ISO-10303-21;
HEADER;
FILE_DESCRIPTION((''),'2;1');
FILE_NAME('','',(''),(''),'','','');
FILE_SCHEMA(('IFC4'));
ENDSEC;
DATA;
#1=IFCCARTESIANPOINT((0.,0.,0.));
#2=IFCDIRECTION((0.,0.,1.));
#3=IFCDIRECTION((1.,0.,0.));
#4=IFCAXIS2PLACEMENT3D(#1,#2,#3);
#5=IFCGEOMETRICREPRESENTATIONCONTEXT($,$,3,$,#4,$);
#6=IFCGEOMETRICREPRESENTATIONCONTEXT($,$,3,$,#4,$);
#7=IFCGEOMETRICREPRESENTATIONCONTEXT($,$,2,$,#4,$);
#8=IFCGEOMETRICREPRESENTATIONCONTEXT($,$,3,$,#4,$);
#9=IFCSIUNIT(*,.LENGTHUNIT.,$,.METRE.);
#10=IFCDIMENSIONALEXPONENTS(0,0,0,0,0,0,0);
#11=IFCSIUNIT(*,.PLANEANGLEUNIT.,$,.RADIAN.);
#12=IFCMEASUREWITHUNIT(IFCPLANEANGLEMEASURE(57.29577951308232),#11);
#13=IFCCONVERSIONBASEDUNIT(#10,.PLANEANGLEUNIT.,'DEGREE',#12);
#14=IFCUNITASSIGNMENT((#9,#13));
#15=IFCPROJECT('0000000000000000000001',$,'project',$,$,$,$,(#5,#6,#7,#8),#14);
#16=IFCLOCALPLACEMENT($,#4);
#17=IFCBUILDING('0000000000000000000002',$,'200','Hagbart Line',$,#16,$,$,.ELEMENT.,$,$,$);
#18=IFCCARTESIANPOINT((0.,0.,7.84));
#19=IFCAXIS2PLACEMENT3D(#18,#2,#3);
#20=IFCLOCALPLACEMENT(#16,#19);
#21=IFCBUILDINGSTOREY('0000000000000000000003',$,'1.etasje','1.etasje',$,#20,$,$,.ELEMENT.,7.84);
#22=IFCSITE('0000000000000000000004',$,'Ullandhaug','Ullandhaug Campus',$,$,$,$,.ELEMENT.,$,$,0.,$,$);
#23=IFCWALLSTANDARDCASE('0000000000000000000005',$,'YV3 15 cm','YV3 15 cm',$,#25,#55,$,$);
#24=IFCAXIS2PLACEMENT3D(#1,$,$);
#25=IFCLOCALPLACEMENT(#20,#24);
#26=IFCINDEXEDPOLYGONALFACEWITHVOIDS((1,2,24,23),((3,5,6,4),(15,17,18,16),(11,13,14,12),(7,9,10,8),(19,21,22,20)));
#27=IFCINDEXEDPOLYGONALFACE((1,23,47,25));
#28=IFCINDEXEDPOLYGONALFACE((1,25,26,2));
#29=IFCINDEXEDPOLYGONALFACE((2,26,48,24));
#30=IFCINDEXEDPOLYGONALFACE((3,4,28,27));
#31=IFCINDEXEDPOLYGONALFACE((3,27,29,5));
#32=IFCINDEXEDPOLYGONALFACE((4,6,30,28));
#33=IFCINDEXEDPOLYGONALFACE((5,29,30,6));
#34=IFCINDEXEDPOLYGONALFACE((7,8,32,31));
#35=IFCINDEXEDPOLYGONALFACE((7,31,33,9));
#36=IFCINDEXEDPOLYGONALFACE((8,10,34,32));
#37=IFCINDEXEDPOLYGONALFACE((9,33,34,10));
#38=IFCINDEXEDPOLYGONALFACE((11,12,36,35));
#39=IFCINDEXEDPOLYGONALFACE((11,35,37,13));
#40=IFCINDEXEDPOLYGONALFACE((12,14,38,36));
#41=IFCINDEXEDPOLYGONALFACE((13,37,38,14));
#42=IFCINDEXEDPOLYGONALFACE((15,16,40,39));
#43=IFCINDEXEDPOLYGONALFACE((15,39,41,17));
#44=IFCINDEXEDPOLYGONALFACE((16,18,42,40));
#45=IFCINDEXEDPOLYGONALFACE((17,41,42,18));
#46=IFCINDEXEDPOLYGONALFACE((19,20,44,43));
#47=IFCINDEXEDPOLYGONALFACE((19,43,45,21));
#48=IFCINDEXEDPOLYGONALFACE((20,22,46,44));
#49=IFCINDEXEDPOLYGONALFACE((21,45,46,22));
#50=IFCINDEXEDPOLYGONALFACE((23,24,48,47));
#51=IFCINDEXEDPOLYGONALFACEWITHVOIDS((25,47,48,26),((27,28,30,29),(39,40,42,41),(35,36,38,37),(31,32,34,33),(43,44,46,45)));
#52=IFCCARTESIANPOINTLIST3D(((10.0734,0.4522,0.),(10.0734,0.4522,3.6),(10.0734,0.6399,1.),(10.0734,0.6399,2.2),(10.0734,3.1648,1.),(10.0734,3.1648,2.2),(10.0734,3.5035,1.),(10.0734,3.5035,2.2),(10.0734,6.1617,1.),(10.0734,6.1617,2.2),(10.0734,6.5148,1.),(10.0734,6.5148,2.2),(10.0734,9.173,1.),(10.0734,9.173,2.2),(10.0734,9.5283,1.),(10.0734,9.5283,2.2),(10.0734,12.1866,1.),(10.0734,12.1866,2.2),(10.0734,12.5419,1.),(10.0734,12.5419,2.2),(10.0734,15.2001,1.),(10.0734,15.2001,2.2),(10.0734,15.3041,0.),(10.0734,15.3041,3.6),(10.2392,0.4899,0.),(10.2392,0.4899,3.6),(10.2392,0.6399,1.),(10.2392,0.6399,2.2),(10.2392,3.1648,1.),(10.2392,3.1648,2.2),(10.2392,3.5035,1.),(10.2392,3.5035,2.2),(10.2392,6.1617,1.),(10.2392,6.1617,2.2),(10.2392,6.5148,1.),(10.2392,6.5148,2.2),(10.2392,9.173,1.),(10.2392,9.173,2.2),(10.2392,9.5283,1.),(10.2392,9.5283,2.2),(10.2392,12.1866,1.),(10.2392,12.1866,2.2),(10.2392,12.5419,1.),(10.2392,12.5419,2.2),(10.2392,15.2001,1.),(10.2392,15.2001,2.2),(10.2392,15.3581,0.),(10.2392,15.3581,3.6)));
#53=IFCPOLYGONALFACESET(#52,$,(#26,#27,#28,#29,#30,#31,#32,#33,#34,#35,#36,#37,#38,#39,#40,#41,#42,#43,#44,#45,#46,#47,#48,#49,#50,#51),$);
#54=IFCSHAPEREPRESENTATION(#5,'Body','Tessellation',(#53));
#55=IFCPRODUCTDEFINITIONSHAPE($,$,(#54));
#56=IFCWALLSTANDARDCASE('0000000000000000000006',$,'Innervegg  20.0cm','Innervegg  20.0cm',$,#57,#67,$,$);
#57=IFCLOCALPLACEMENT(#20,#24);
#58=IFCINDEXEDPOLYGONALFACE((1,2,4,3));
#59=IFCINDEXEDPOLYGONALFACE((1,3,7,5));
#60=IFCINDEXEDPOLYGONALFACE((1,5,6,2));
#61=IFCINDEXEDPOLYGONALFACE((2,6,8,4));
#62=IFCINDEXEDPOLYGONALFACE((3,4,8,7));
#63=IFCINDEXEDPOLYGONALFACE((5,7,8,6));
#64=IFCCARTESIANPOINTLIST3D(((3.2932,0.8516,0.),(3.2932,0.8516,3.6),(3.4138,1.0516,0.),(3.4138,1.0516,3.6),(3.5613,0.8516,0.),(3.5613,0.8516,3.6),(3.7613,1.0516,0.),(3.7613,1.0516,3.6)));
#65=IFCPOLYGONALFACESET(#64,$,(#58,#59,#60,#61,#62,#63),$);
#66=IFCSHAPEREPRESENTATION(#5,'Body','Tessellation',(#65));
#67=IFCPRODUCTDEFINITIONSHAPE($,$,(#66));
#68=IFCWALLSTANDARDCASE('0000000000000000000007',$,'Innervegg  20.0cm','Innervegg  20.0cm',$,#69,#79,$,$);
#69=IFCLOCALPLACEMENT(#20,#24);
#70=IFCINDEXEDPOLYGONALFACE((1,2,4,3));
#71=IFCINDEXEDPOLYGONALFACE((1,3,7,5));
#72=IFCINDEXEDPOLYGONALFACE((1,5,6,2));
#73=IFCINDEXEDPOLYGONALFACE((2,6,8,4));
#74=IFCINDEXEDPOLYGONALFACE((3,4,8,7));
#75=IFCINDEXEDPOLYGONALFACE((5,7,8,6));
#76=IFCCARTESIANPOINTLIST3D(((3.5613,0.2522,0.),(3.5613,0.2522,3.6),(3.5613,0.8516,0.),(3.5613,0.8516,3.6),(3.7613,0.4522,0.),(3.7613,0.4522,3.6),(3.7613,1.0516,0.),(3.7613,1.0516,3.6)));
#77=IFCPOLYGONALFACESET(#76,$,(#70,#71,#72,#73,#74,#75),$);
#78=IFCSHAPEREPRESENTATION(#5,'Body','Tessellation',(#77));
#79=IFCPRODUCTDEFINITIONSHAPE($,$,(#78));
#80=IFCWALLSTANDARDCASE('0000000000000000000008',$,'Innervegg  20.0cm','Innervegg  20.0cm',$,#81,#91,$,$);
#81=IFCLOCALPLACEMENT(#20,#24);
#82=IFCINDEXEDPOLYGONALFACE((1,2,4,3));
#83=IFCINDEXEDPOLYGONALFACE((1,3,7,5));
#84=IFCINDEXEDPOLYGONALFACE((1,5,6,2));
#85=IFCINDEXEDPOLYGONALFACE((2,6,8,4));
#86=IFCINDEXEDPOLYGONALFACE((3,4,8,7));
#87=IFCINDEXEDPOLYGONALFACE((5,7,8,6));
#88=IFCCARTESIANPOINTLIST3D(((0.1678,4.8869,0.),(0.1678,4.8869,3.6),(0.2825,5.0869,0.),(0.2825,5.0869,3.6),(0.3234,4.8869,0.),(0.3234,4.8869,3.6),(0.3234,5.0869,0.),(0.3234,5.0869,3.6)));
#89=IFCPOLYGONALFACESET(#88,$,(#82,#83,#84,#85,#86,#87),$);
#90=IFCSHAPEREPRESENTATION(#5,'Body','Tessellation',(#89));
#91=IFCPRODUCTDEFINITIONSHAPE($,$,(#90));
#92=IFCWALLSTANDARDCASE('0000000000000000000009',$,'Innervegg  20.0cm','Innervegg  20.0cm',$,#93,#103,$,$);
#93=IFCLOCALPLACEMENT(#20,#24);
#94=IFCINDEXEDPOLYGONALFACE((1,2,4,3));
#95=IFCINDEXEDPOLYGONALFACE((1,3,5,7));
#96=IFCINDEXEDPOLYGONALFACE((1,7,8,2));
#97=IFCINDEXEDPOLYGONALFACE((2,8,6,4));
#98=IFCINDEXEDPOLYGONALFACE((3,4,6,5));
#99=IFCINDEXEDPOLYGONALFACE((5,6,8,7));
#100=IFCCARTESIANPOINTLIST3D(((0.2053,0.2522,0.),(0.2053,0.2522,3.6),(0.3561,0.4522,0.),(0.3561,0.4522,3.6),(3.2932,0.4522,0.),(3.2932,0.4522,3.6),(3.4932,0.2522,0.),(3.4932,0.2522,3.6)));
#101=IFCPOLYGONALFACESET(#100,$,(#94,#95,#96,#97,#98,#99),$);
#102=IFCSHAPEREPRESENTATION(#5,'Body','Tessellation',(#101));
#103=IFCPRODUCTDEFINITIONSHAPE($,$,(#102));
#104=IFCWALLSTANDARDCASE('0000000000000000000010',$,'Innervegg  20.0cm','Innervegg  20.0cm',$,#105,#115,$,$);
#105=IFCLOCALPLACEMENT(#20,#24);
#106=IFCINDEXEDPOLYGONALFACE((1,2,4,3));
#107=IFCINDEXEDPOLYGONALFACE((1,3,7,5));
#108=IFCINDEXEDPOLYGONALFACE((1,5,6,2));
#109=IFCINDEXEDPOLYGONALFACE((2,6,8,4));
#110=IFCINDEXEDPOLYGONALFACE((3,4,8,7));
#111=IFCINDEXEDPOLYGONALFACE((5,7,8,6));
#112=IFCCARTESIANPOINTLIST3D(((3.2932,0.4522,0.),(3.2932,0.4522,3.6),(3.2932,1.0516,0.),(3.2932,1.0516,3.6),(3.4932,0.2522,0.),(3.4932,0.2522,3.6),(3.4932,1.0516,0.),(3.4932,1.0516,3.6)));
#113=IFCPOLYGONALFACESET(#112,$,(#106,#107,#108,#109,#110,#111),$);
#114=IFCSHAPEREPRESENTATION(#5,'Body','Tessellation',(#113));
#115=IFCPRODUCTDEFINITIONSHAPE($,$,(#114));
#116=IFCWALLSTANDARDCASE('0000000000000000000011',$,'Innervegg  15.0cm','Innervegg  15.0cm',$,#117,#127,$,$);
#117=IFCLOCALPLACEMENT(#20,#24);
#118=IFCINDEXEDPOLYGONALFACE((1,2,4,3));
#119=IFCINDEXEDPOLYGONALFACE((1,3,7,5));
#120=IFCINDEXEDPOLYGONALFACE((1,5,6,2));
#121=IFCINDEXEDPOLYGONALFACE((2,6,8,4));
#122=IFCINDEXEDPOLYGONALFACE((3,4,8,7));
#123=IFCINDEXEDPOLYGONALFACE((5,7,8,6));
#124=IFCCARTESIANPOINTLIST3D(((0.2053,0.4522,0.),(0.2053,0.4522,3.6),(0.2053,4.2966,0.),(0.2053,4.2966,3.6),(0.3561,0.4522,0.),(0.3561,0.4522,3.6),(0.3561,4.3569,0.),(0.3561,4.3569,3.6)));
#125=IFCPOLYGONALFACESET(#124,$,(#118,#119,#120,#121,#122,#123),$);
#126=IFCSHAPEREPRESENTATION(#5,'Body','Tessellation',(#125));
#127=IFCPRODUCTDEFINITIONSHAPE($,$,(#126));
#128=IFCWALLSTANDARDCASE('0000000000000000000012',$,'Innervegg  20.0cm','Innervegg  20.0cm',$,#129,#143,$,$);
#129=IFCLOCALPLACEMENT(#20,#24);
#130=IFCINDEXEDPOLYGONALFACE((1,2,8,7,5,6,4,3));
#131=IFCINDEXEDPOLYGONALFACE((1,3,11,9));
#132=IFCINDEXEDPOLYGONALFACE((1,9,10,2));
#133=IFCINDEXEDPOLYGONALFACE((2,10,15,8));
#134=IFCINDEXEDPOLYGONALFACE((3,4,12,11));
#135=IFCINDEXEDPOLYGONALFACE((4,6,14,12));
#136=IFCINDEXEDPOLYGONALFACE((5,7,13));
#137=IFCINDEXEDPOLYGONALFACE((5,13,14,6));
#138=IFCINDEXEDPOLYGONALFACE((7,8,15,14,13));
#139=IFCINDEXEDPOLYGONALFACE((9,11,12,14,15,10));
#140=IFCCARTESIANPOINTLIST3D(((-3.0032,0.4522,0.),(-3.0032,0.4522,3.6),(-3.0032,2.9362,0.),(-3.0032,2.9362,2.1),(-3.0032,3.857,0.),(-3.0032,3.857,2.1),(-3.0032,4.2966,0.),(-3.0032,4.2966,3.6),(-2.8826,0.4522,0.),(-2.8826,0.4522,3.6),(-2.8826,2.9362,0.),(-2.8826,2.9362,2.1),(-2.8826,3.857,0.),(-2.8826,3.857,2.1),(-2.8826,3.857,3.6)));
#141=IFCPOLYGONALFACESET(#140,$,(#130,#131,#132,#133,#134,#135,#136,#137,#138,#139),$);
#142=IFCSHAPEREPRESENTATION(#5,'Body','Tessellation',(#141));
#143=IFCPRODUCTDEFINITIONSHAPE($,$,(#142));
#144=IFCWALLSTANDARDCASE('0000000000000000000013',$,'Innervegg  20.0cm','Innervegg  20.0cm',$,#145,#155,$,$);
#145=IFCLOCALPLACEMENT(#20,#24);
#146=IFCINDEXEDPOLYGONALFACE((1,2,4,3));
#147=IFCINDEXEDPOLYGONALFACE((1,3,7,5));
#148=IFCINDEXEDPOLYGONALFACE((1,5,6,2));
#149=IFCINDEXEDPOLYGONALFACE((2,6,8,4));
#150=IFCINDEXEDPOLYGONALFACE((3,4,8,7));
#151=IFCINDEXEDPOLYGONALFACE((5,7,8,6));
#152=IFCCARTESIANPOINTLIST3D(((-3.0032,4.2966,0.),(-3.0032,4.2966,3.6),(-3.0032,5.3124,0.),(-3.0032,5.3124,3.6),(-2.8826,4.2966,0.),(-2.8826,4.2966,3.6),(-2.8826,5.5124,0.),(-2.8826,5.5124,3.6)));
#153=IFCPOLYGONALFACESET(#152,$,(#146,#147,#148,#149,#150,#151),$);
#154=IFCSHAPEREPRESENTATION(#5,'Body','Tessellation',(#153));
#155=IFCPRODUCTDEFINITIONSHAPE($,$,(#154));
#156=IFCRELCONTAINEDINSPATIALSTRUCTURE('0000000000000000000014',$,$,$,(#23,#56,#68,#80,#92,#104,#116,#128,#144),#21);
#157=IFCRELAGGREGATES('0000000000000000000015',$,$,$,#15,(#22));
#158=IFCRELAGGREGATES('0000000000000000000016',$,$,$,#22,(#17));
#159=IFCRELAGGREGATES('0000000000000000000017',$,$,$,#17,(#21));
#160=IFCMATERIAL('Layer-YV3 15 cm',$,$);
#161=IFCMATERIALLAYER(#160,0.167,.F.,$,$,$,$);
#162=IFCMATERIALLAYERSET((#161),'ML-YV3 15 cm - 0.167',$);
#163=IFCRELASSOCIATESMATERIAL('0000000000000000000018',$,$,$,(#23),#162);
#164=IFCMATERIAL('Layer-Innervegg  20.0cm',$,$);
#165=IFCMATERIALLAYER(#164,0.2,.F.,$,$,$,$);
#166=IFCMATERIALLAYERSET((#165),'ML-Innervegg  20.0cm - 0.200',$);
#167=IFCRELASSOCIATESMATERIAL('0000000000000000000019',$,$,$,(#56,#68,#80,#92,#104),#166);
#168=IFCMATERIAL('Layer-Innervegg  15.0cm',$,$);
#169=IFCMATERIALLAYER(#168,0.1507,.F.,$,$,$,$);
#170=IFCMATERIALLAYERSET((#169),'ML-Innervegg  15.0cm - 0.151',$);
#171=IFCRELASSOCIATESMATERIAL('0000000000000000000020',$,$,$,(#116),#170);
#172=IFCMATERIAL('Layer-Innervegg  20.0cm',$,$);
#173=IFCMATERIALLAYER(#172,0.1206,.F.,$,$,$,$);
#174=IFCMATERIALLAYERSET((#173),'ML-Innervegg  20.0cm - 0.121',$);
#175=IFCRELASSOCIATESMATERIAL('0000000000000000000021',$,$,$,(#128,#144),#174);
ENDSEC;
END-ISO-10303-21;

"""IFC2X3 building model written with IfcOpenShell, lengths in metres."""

from ifc_helpers import new_model, entity, si_unit, converted_unit, frame, origin_with_axes, place, context, project, spatial, polyline, outline, extrude, material, layer, layer_set, layer_usage, element, save


model = new_model("IFC2X3")

# Units and contexts
context_of_model_1 = context(None, 3, world=origin_with_axes())
context_of_model_2 = context(None, 3, world=origin_with_axes())
context_of_model_3 = context(None, 2, world=origin_with_axes())
context_of_model_4 = context(None, 3, world=origin_with_axes())
ifc_project = project(units=[si_unit("LENGTHUNIT", "METRE"), converted_unit("PLANEANGLEUNIT", "DEGREE", entity("IfcPlaneAngleMeasure", 57.29577951308232), si_unit("PLANEANGLEUNIT", "RADIAN"), dimensions=[0, 0, 0, 0, 0, 0, 0])], contexts=[context_of_model_1, context_of_model_2, context_of_model_3, context_of_model_4])

# Site, building, storey
site = spatial("IfcSite", under=ifc_project, Name="Ullandhaug", Description="Ullandhaug Campus", CompositionType="ELEMENT", RefElevation=0.0)
building_placement = place(None, origin_with_axes())
building = spatial("IfcBuilding", under=site, at=building_placement, Name="200", Description="Hagbart Line", CompositionType="ELEMENT")
storey_placement = place(building_placement, frame((0.0, 0.0, 7.84), z_axis=(0.0, 0.0, 1.0), x_axis=(1.0, 0.0, 0.0)))
storey = spatial("IfcBuildingStorey", under=building, at=storey_placement, Name="1.etasje", Description="1.etasje", CompositionType="ELEMENT", Elevation=7.84)

# Shared definitions
ifc_material_1 = material(Name="Layer-Innervegg  20.0cm")
ifc_layer_1 = layer(ifc_material_1, 0.2, ventilated=False)
ifc_layer_set_1 = layer_set([ifc_layer_1], Name="ML-Innervegg  20.0cm - 0.200")
ifc_layer_usage_1 = layer_usage(ifc_layer_set_1, "AXIS2", "POSITIVE", 0.0)

# Wall, openings
ifc_material_2 = material(Name="Layer-YV3 15 cm")
ifc_layer_2 = layer(ifc_material_2, 0.167, ventilated=False)
ifc_layer_set_2 = layer_set([ifc_layer_2], Name="ML-YV3 15 cm - 0.167")
ifc_layer_usage_2 = layer_usage(ifc_layer_set_2, "AXIS2", "POSITIVE", 0.0)
wall_1_placement = place(storey_placement, frame((10.2392, 0.4899, 0.0), z_axis=(0.0, 0.0, 1.0), x_axis=(0.0, 1.0, 0.0)))
wall_1 = element("IfcWallStandardCase", 1, at=wall_1_placement, inside=storey, material=ifc_layer_usage_2, Name="YV3 15 cm", Description="YV3 15 cm", context=context_of_model_1, shape_type="SweptSolid", body=[
    extrude(outline(polyline([(0.0, 0.0), (14.8682, 0.0), (14.8142, 0.1658), (-0.0377, 0.1658), (0.0, 0.0)])), frame((0.0, 0.0, 0.0), z_axis=(0.0, 0.0, 1.0), x_axis=(1.0, 0.0, 0.0)), (0.0, 0.0, 1.0), 3.6),
])
opening_1_placement = place(wall_1_placement, frame((3.0136, 0.1658, 1.0), z_axis=(0.0, 0.0, 1.0), x_axis=(1.0, 0.0, 0.0)))
element("IfcOpeningElement", 2, at=opening_1_placement, cuts=wall_1, context=context_of_model_1, shape_type="SweptSolid", body=[
    extrude(outline(polyline([(0.0, 0.0), (1.2, 0.0), (1.2, 2.6582), (0.0, 2.6582), (0.0, 0.0)])), frame((0.0, 0.0, 0.0), z_axis=(0.0, 1.0, 0.0), x_axis=(0.0, 0.0, 1.0)), (0.0, 0.0, -1.0), 0.167),
])
opening_2_placement = place(wall_1_placement, frame((6.0249, 0.1658, 1.0), z_axis=(0.0, 0.0, 1.0), x_axis=(1.0, 0.0, 0.0)))
element("IfcOpeningElement", 3, at=opening_2_placement, cuts=wall_1, context=context_of_model_1, shape_type="SweptSolid", body=[
    extrude(outline(polyline([(0.0, 0.0), (1.2, 0.0), (1.2, 2.6582), (0.0, 2.6582), (0.0, 0.0)])), frame((0.0, 0.0, 0.0), z_axis=(0.0, 1.0, 0.0), x_axis=(0.0, 0.0, 1.0)), (0.0, 0.0, -1.0), 0.167),
])
opening_3_placement = place(wall_1_placement, frame((9.0384, 0.1658, 1.0), z_axis=(0.0, 0.0, 1.0), x_axis=(1.0, 0.0, 0.0)))
element("IfcOpeningElement", 4, at=opening_3_placement, cuts=wall_1, context=context_of_model_1, shape_type="SweptSolid", body=[
    extrude(outline(polyline([(0.0, 0.0), (1.2, 0.0), (1.2, 2.6582), (0.0, 2.6582), (0.0, 0.0)])), frame((0.0, 0.0, 0.0), z_axis=(0.0, 1.0, 0.0), x_axis=(0.0, 0.0, 1.0)), (0.0, 0.0, -1.0), 0.167),
])
opening_4_placement = place(wall_1_placement, frame((12.052, 0.1658, 1.0), z_axis=(0.0, 0.0, 1.0), x_axis=(1.0, 0.0, 0.0)))
element("IfcOpeningElement", 5, at=opening_4_placement, cuts=wall_1, context=context_of_model_1, shape_type="SweptSolid", body=[
    extrude(outline(polyline([(0.0, 0.0), (1.2, 0.0), (1.2, 2.6582), (0.0, 2.6582), (0.0, 0.0)])), frame((0.0, 0.0, 0.0), z_axis=(0.0, 1.0, 0.0), x_axis=(0.0, 0.0, 1.0)), (0.0, 0.0, -1.0), 0.167),
])
opening_5_placement = place(wall_1_placement, frame((0.15, 0.1658, 1.0), z_axis=(0.0, 0.0, 1.0), x_axis=(1.0, 0.0, 0.0)))
element("IfcOpeningElement", 6, at=opening_5_placement, cuts=wall_1, context=context_of_model_1, shape_type="SweptSolid", body=[
    extrude(outline(polyline([(0.0, 0.0), (1.2, 0.0), (1.2, 2.5249), (0.0, 2.5249), (0.0, 0.0)])), frame((0.0, 0.0, 0.0), z_axis=(0.0, 1.0, 0.0), x_axis=(0.0, 0.0, 1.0)), (0.0, 0.0, -1.0), 0.167),
])

# Walls
wall_2_placement = place(storey_placement, frame((3.2932, 0.8516, 0.0), z_axis=(0.0, 0.0, 1.0), x_axis=(1.0, 0.0, 0.0)))
element("IfcWallStandardCase", 7, at=wall_2_placement, inside=storey, material=ifc_layer_usage_1, Name="Innervegg  20.0cm", Description="Innervegg  20.0cm", context=context_of_model_1, shape_type="SweptSolid", body=[
    extrude(outline(polyline([(0.0, 0.0), (0.2681, 0.0), (0.4681, 0.2), (0.1206, 0.2), (0.0, 0.0)])), origin_with_axes(), (0.0, 0.0, 1.0), 3.6),
])
wall_3_placement = place(storey_placement, frame((3.5613, 0.8516, 0.0), z_axis=(0.0, 0.0, 1.0), x_axis=(0.0, -1.0, 0.0)))
element("IfcWallStandardCase", 8, at=wall_3_placement, inside=storey, material=ifc_layer_usage_1, Name="Innervegg  20.0cm", Description="Innervegg  20.0cm", context=context_of_model_1, shape_type="SweptSolid", body=[
    extrude(outline(polyline([(0.0, 0.0), (0.5994, 0.0), (0.3994, 0.2), (-0.2, 0.2), (0.0, 0.0)])), frame((0.0, 0.0, 0.0), z_axis=(0.0, 0.0, 1.0), x_axis=(1.0, 0.0, 0.0)), (0.0, 0.0, 1.0), 3.6),
])
wall_4_placement = place(storey_placement, frame((0.1678, 4.8869, 0.0), z_axis=(0.0, 0.0, 1.0), x_axis=(1.0, 0.0, 0.0)))
element("IfcWallStandardCase", 9, at=wall_4_placement, inside=storey, material=ifc_layer_usage_1, Name="Innervegg  20.0cm", Description="Innervegg  20.0cm", context=context_of_model_1, shape_type="SweptSolid", body=[
    extrude(outline(polyline([(0.0, 0.0), (0.1557, 0.0), (0.1557, 0.2), (0.1147, 0.2), (0.0, 0.0)])), origin_with_axes(), (0.0, 0.0, 1.0), 3.6),
])
wall_5_placement = place(storey_placement, frame((0.2053, 0.2522, 0.0), z_axis=(0.0, 0.0, 1.0), x_axis=(1.0, 0.0, 0.0)))
element("IfcWallStandardCase", 10, at=wall_5_placement, inside=storey, material=ifc_layer_usage_1, Name="Innervegg  20.0cm", Description="Innervegg  20.0cm", context=context_of_model_1, shape_type="SweptSolid", body=[
    extrude(outline(polyline([(0.0, 0.0), (3.2878, 0.0), (3.0878, 0.2), (0.1507, 0.2), (0.0, 0.0)])), frame((0.0, 0.0, 0.0), z_axis=(0.0, 0.0, 1.0), x_axis=(1.0, 0.0, 0.0)), (0.0, 0.0, 1.0), 3.6),
])
wall_6_placement = place(storey_placement, frame((3.4932, 0.2522, 0.0), z_axis=(0.0, 0.0, 1.0), x_axis=(0.0, 1.0, 0.0)))
element("IfcWallStandardCase", 11, at=wall_6_placement, inside=storey, material=ifc_layer_usage_1, Name="Innervegg  20.0cm", Description="Innervegg  20.0cm", context=context_of_model_1, shape_type="SweptSolid", body=[
    extrude(outline(polyline([(0.0, 0.0), (0.7994, 0.0), (0.7994, 0.2), (0.2, 0.2), (0.0, 0.0)])), frame((0.0, 0.0, 0.0), z_axis=(0.0, 0.0, 1.0), x_axis=(1.0, 0.0, 0.0)), (0.0, 0.0, 1.0), 3.6),
])
ifc_material_3 = material(Name="Layer-Innervegg  15.0cm")
ifc_layer_3 = layer(ifc_material_3, 0.1507, ventilated=False)
ifc_layer_set_3 = layer_set([ifc_layer_3], Name="ML-Innervegg  15.0cm - 0.151")
ifc_layer_usage_3 = layer_usage(ifc_layer_set_3, "AXIS2", "POSITIVE", 0.0)
wall_7_placement = place(storey_placement, frame((0.2053, 4.2966, 0.0), z_axis=(0.0, 0.0, 1.0), x_axis=(0.0, -1.0, 0.0)))
element("IfcWallStandardCase", 12, at=wall_7_placement, inside=storey, material=ifc_layer_usage_3, Name="Innervegg  15.0cm", Description="Innervegg  15.0cm", context=context_of_model_1, shape_type="SweptSolid", body=[
    extrude(outline(polyline([(0.0, 0.0), (3.8444, 0.0), (3.8444, 0.1507), (-0.0603, 0.1507), (0.0, 0.0)])), frame((0.0, 0.0, 0.0), z_axis=(0.0, 0.0, 1.0), x_axis=(1.0, 0.0, 0.0)), (0.0, 0.0, 1.0), 3.6),
])

# Wall, opening
ifc_material_4 = material(Name="Layer-Innervegg  20.0cm")
ifc_layer_4 = layer(ifc_material_4, 0.1206, ventilated=False)
ifc_layer_set_4 = layer_set([ifc_layer_4], Name="ML-Innervegg  20.0cm - 0.121")
ifc_layer_usage_4 = layer_usage(ifc_layer_set_4, "AXIS2", "POSITIVE", 0.0)
wall_8_placement = place(storey_placement, frame((-2.8826, 0.4522, 0.0), z_axis=(0.0, 0.0, 1.0), x_axis=(0.0, 1.0, 0.0)))
wall_8 = element("IfcWallStandardCase", 13, at=wall_8_placement, inside=storey, material=ifc_layer_usage_4, Name="Innervegg  20.0cm", Description="Innervegg  20.0cm", context=context_of_model_1, shape_type="SweptSolid", body=[
    extrude(outline(polyline([(0.0, 0.0), (3.4047, 0.0), (3.8444, 0.1206), (0.0, 0.1206), (0.0, 0.0)])), frame((0.0, 0.0, 0.0), z_axis=(0.0, 0.0, 1.0), x_axis=(1.0, 0.0, 0.0)), (0.0, 0.0, 1.0), 3.6),
])
opening_6_placement = place(wall_8_placement, frame((2.484, 0.1206, 0.0), z_axis=(0.0, 0.0, 1.0), x_axis=(1.0, 0.0, 0.0)))
element("IfcOpeningElement", 14, at=opening_6_placement, cuts=wall_8, context=context_of_model_1, shape_type="SweptSolid", body=[
    extrude(outline(polyline([(0.0, 0.0), (2.1, 0.0), (2.1, 0.9208), (0.0, 0.9208), (0.0, 0.0)])), frame((0.0, 0.0, 0.0), z_axis=(0.0, 1.0, 0.0), x_axis=(0.0, 0.0, 1.0)), (0.0, 0.0, -1.0), 0.1206),
])

# Wall
wall_9_placement = place(storey_placement, frame((-2.8826, 4.2966, 0.0), z_axis=(0.0, 0.0, 1.0), x_axis=(0.0, 1.0, 0.0)))
element("IfcWallStandardCase", 15, at=wall_9_placement, inside=storey, material=ifc_layer_usage_4, Name="Innervegg  20.0cm", Description="Innervegg  20.0cm", context=context_of_model_1, shape_type="SweptSolid", body=[
    extrude(outline(polyline([(0.0, 0.0), (1.2158, 0.0), (1.0158, 0.1206), (0.0, 0.1206), (0.0, 0.0)])), frame((0.0, 0.0, 0.0), z_axis=(0.0, 0.0, 1.0), x_axis=(1.0, 0.0, 0.0)), (0.0, 0.0, 1.0), 3.6),
])

save(model, "model.ifc")
